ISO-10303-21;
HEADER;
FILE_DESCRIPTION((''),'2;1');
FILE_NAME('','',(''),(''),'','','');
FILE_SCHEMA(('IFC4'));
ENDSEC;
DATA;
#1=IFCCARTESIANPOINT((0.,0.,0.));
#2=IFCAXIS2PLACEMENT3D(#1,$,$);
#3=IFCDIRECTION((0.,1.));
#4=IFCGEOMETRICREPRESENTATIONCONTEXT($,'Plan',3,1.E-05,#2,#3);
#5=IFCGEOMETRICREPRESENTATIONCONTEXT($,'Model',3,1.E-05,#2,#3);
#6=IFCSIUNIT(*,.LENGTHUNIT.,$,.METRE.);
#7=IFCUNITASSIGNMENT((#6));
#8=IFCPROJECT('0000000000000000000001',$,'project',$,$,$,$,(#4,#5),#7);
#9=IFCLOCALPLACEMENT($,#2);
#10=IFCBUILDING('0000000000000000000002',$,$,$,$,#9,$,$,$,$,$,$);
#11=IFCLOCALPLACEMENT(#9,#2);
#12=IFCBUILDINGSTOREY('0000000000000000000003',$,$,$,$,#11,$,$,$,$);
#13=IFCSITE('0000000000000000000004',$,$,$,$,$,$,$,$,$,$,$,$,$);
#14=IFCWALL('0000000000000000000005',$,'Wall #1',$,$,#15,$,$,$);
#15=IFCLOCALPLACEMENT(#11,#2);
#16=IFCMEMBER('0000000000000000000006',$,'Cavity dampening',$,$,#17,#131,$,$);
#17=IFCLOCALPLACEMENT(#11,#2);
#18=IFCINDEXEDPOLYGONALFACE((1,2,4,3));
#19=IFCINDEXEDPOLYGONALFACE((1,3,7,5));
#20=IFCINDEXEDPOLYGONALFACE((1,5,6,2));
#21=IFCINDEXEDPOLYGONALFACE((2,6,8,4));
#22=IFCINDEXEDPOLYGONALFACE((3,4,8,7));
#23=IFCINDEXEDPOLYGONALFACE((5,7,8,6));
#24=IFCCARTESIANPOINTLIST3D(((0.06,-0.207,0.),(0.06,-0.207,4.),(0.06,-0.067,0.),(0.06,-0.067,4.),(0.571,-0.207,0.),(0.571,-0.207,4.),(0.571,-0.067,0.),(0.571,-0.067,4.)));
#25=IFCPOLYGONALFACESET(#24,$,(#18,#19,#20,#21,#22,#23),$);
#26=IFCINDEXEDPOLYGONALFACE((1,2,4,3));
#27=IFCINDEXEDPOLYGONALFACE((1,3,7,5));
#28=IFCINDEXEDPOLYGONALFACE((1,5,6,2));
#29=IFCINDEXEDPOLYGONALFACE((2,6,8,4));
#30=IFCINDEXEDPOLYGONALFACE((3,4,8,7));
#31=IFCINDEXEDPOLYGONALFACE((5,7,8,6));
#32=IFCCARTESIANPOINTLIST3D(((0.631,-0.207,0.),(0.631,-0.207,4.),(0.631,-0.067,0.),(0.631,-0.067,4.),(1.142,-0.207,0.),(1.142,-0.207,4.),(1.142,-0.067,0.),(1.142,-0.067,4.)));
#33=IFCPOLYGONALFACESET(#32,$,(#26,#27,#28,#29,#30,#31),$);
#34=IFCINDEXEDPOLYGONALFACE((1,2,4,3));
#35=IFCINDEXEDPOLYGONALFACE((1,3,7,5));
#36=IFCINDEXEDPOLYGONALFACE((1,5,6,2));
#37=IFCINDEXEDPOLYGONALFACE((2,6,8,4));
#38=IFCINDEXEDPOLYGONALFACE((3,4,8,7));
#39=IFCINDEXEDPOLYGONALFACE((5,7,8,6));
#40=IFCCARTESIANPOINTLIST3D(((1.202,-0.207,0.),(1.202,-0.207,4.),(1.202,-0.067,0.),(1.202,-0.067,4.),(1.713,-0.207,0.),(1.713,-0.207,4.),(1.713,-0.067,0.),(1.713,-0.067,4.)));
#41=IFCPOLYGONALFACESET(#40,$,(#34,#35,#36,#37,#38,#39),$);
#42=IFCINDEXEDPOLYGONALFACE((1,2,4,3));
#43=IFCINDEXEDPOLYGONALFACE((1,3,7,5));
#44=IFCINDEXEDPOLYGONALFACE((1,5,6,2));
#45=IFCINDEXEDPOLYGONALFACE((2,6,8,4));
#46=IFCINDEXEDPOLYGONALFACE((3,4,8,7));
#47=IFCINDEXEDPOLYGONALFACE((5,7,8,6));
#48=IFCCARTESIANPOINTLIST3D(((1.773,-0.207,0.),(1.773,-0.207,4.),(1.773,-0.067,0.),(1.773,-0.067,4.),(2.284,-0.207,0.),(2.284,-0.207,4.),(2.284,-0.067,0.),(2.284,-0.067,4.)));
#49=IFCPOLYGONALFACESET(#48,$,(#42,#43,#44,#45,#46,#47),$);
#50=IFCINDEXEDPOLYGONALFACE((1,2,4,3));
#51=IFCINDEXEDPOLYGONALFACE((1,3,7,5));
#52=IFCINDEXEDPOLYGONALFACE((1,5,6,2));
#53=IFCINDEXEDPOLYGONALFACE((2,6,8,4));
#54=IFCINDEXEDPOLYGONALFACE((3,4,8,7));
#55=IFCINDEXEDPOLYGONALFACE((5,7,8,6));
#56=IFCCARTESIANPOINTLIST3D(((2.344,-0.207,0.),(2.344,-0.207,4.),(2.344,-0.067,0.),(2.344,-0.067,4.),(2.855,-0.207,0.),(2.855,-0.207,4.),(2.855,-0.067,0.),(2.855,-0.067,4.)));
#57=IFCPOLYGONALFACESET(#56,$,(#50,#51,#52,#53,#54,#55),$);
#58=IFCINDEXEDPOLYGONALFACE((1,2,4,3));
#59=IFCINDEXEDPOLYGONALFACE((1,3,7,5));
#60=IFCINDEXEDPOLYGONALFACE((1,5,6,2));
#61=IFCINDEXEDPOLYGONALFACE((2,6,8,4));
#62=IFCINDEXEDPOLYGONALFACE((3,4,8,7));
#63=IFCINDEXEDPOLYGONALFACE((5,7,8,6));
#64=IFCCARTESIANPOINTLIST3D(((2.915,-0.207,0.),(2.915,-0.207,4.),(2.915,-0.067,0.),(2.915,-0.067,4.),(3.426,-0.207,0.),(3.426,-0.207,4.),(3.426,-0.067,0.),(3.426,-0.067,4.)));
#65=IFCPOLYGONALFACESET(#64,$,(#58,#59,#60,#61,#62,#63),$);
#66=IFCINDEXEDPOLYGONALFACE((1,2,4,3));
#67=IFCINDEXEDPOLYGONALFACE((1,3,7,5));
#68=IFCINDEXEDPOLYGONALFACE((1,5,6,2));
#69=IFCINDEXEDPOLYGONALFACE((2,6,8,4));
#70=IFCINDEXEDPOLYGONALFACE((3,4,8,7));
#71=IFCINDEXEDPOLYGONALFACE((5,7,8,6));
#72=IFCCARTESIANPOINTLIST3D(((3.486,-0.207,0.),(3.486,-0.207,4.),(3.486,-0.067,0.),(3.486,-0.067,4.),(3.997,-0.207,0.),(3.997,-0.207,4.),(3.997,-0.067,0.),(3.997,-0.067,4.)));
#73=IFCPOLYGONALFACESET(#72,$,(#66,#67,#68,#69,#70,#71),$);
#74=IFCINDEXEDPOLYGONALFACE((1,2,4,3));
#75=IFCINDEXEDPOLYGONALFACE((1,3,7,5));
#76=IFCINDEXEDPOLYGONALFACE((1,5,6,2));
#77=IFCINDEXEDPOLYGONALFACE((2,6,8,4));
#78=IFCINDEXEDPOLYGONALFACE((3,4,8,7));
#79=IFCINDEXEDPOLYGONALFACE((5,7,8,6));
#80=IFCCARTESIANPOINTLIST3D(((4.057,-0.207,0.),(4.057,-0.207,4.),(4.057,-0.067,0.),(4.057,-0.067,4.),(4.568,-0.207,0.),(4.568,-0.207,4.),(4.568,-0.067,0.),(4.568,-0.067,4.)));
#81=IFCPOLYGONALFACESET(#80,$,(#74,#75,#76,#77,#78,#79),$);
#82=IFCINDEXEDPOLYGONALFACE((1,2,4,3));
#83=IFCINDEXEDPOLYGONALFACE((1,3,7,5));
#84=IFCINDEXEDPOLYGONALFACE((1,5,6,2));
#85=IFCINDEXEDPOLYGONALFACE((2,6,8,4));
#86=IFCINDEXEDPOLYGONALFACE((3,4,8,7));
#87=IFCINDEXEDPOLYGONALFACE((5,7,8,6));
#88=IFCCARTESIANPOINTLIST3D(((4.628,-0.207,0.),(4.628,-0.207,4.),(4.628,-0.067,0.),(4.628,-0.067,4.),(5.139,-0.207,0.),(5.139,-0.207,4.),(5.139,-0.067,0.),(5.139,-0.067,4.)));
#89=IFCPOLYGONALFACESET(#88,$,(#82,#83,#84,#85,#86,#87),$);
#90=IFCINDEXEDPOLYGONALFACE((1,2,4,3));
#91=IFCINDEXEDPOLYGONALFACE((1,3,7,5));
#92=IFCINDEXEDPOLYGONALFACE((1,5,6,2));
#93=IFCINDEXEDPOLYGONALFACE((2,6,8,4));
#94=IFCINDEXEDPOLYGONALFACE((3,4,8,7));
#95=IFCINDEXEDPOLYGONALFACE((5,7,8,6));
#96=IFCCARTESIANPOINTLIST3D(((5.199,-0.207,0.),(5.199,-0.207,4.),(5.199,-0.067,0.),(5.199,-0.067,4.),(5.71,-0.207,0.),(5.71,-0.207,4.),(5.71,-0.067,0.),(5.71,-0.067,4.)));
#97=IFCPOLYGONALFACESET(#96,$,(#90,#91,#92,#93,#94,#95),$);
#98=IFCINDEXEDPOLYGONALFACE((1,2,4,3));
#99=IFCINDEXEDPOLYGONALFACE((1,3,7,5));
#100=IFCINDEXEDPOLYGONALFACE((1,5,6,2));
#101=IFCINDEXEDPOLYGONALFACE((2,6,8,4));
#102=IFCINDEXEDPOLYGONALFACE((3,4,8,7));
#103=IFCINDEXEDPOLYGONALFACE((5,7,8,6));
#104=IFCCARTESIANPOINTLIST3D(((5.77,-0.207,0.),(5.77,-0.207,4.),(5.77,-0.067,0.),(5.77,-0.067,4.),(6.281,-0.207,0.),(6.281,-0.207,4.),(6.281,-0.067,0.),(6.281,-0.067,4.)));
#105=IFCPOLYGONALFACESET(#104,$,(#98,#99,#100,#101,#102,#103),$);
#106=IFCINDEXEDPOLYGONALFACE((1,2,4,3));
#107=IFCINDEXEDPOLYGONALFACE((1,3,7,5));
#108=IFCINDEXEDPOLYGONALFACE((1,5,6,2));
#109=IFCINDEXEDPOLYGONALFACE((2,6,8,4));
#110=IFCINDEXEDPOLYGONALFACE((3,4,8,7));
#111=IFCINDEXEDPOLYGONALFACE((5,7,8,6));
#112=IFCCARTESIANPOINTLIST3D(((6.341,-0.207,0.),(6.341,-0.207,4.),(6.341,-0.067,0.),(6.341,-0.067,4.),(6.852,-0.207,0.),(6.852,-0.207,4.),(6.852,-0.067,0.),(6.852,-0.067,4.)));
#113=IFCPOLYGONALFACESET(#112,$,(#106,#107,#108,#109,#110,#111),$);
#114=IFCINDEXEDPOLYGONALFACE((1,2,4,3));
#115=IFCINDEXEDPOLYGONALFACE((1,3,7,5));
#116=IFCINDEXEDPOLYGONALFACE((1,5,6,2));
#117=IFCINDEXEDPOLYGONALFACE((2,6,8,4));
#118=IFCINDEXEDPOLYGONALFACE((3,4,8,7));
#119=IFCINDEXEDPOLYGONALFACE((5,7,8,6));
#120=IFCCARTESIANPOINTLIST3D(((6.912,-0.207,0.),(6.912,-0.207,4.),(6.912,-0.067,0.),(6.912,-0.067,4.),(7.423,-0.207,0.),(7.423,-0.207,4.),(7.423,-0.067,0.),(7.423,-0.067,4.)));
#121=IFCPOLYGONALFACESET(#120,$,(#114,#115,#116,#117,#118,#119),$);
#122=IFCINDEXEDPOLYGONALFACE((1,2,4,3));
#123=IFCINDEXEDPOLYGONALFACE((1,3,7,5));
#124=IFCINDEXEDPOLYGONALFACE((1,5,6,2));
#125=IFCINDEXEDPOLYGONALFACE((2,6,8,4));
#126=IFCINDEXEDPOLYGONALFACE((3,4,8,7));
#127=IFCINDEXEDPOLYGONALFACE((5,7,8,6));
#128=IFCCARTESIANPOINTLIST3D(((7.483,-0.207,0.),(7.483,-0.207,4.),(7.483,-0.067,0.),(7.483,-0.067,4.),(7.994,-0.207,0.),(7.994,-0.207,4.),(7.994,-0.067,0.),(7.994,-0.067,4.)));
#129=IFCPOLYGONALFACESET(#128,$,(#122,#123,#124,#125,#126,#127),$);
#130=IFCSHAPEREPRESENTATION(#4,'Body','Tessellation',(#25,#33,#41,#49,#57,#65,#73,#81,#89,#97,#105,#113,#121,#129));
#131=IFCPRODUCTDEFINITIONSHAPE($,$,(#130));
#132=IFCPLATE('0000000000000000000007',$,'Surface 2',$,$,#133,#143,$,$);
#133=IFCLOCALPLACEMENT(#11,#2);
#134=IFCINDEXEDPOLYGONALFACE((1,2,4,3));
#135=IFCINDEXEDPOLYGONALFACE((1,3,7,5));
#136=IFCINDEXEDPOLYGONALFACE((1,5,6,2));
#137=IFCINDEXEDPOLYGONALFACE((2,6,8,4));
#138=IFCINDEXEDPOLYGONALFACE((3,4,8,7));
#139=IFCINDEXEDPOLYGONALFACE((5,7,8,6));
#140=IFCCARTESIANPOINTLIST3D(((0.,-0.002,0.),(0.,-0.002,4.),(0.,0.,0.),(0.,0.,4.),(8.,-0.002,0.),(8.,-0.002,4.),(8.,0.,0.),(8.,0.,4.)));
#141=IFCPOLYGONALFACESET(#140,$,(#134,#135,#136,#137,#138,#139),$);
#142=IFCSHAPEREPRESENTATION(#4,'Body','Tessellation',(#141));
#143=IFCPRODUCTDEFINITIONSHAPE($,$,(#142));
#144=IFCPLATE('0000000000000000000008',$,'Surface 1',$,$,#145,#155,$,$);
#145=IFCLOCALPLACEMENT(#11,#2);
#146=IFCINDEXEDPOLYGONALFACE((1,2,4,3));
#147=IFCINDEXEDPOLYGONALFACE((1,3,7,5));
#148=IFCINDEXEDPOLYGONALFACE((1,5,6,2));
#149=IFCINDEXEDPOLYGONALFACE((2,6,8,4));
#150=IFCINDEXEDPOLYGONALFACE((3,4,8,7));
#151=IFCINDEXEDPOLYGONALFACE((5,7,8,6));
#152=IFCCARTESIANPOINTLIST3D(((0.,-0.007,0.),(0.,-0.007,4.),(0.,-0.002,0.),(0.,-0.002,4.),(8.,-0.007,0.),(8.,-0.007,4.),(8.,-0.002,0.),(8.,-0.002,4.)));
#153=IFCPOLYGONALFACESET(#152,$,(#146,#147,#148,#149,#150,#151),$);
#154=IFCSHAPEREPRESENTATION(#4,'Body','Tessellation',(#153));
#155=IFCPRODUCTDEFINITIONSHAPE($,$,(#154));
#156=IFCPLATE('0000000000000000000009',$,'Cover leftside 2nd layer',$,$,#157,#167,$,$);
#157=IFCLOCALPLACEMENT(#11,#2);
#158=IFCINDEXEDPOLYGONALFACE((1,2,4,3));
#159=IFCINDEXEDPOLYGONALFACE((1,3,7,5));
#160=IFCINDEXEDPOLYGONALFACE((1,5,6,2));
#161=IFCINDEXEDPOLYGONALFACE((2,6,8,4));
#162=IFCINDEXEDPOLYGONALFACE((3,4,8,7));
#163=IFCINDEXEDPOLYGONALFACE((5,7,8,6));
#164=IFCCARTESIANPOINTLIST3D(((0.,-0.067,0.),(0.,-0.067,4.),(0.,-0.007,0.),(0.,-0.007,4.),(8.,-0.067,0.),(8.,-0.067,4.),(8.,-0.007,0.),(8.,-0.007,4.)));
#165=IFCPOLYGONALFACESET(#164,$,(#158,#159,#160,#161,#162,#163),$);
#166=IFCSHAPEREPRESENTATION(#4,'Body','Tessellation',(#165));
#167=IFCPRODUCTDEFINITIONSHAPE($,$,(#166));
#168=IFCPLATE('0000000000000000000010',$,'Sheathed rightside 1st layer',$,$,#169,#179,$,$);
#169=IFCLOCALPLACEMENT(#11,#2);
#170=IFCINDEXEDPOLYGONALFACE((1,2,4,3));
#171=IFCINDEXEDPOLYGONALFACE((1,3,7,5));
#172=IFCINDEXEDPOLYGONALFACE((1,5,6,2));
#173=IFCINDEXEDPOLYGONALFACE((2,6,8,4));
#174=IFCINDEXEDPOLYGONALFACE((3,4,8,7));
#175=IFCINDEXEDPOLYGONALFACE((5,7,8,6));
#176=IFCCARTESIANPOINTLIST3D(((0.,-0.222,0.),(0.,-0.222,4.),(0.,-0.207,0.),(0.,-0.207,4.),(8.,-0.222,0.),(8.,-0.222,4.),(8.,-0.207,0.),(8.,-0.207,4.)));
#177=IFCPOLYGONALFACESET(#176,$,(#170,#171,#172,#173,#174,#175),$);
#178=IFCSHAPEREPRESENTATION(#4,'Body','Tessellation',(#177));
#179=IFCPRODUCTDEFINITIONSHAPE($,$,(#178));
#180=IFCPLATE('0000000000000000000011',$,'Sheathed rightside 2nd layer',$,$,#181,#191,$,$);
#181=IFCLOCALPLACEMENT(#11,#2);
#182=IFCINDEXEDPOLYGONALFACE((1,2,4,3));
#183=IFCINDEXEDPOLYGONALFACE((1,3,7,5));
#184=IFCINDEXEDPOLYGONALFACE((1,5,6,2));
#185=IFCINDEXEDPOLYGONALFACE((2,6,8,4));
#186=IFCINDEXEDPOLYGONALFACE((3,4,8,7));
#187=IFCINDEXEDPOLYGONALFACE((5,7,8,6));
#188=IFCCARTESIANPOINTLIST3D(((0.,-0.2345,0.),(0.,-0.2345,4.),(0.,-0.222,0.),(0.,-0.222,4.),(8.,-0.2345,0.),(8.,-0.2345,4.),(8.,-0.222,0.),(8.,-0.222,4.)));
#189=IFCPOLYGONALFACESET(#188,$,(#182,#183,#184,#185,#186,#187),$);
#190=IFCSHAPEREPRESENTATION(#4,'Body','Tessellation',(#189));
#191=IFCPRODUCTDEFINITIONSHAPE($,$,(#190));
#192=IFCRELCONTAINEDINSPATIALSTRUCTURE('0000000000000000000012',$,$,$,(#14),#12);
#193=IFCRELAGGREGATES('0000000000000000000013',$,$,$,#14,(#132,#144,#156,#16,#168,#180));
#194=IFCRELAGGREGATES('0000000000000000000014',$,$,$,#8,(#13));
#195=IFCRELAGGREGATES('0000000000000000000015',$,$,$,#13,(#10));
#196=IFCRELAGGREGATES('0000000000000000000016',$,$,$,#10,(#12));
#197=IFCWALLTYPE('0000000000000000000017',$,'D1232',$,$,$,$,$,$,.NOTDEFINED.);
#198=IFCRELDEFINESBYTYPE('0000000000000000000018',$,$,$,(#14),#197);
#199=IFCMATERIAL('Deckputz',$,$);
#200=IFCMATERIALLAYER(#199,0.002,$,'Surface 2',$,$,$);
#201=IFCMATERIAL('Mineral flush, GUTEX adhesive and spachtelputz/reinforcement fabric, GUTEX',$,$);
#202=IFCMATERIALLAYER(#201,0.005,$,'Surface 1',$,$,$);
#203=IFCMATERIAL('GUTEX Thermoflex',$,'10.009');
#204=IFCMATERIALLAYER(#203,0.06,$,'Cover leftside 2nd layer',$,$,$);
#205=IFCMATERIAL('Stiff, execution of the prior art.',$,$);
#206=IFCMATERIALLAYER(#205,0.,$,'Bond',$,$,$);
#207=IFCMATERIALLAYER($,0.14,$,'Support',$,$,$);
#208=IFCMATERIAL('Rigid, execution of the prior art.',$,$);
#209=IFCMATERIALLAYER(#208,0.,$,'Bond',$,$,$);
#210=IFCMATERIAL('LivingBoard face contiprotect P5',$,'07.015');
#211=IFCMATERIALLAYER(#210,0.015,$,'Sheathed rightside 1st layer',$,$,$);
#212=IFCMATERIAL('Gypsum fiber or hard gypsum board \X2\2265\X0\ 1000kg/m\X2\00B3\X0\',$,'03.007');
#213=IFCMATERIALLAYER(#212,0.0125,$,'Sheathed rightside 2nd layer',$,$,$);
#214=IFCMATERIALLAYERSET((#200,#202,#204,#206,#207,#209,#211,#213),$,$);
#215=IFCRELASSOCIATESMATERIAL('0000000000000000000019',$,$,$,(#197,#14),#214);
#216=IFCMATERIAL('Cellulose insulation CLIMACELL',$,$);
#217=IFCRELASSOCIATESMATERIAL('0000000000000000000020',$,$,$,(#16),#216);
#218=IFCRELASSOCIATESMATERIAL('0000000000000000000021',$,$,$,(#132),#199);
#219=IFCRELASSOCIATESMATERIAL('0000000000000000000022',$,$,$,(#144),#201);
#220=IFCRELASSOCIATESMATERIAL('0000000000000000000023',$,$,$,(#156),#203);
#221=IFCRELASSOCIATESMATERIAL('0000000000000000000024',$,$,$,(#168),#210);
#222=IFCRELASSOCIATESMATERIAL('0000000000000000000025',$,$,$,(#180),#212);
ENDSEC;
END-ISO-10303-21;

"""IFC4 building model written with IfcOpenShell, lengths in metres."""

from ifc_helpers import new_model, si_unit, direction, frame, frame_2d, origin, origin_with_axes, place, context, project, spatial, rectangle, extrude, material, layer, layer_set, type_object, element, aggregate, save


model = new_model("IFC4")

# Units and contexts
plan_context = context("Plan", 3, precision=1e-05, world=origin(), true_north=direction((0.0, 1.0)))
model_context = context("Model", 3, precision=1e-05, world=origin(), true_north=direction((0.0, 1.0)))
ifc_project = project(units=[si_unit("LENGTHUNIT", "METRE")], contexts=[plan_context, model_context])

# Site, building, storey
site = spatial("IfcSite", under=ifc_project)
building_placement = place(None, origin())
building = spatial("IfcBuilding", under=site, at=building_placement)
storey_placement = place(building_placement, origin())
storey = spatial("IfcBuildingStorey", under=building, at=storey_placement)

# Wall, member, plates
ifc_material_1 = material(Name="Deckputz")
ifc_layer_1 = layer(ifc_material_1, 0.002, Name="Surface 2")
ifc_material_2 = material(Name="Mineral flush, GUTEX adhesive and spachtelputz/reinforcement fabric, GUTEX")
ifc_layer_2 = layer(ifc_material_2, 0.005, Name="Surface 1")
ifc_material_3 = material(Name="GUTEX Thermoflex", Category="10.009")
ifc_layer_3 = layer(ifc_material_3, 0.06, Name="Cover leftside 2nd layer")
ifc_material_4 = material(Name="Stiff, execution of the prior art.")
ifc_layer_4 = layer(ifc_material_4, 0.0, Name="Bond")
ifc_layer_5 = layer(None, 0.14, Name="Support")
ifc_material_5 = material(Name="Rigid, execution of the prior art.")
ifc_layer_6 = layer(ifc_material_5, 0.0, Name="Bond")
ifc_material_6 = material(Name="LivingBoard face contiprotect P5", Category="07.015")
ifc_layer_7 = layer(ifc_material_6, 0.015, Name="Sheathed rightside 1st layer")
ifc_material_7 = material(Name="Gypsum fiber or hard gypsum board ≥ 1000kg/m³", Category="03.007")
ifc_layer_8 = layer(ifc_material_7, 0.0125, Name="Sheathed rightside 2nd layer")
ifc_layer_set = layer_set([ifc_layer_1, ifc_layer_2, ifc_layer_3, ifc_layer_4, ifc_layer_5, ifc_layer_6, ifc_layer_7, ifc_layer_8])
wall_type = type_object("IfcWallType", Name="D1232", PredefinedType="NOTDEFINED", material=ifc_layer_set)
wall_placement = place(None, frame((0.0, 0.0, 0.0), z_axis=(0.0, -1.0, 0.0), x_axis=(1.0, 0.0, 0.0)))
wall = element("IfcWall", 1, at=wall_placement, inside=storey, type_object=wall_type, material=ifc_layer_set, Name="Wall #1")
ifc_material_8 = material(Name="Cellulose insulation CLIMACELL")
member_1_placement = place(wall_placement, origin())
member_1 = element("IfcMember", 2, at=member_1_placement, material=ifc_material_8, Name="Cavity dampening", context=plan_context, shape_type="SweptSolid", body=[
    extrude(rectangle(XDim=0.511, YDim=0.14, at=frame_2d((0.2555, 0.07), x_axis=(1.0, 0.0))), frame((0.06, 4.0, 0.067), z_axis=(0.0, -1.0, 0.0), x_axis=(1.0, 0.0, 0.0)), (0.0, 0.0, 1.0), 4.0),
    extrude(rectangle(XDim=0.511, YDim=0.14, at=frame_2d((0.2555, 0.07), x_axis=(1.0, 0.0))), frame((0.631, 4.0, 0.067), z_axis=(0.0, -1.0, 0.0), x_axis=(1.0, 0.0, 0.0)), (0.0, 0.0, 1.0), 4.0),
    extrude(rectangle(XDim=0.511, YDim=0.14, at=frame_2d((0.2555, 0.07), x_axis=(1.0, 0.0))), frame((1.202, 4.0, 0.067), z_axis=(0.0, -1.0, 0.0), x_axis=(1.0, 0.0, 0.0)), (0.0, 0.0, 1.0), 4.0),
    extrude(rectangle(XDim=0.511, YDim=0.14, at=frame_2d((0.2555, 0.07), x_axis=(1.0, 0.0))), frame((1.773, 4.0, 0.067), z_axis=(0.0, -1.0, 0.0), x_axis=(1.0, 0.0, 0.0)), (0.0, 0.0, 1.0), 4.0),
    extrude(rectangle(XDim=0.511, YDim=0.14, at=frame_2d((0.2555, 0.07), x_axis=(1.0, 0.0))), frame((2.344, 4.0, 0.067), z_axis=(0.0, -1.0, 0.0), x_axis=(1.0, 0.0, 0.0)), (0.0, 0.0, 1.0), 4.0),
    extrude(rectangle(XDim=0.511, YDim=0.14, at=frame_2d((0.2555, 0.07), x_axis=(1.0, 0.0))), frame((2.915, 4.0, 0.067), z_axis=(0.0, -1.0, 0.0), x_axis=(1.0, 0.0, 0.0)), (0.0, 0.0, 1.0), 4.0),
    extrude(rectangle(XDim=0.511, YDim=0.14, at=frame_2d((0.2555, 0.07), x_axis=(1.0, 0.0))), frame((3.486, 4.0, 0.067), z_axis=(0.0, -1.0, 0.0), x_axis=(1.0, 0.0, 0.0)), (0.0, 0.0, 1.0), 4.0),
    extrude(rectangle(XDim=0.511, YDim=0.14, at=frame_2d((0.2555, 0.07), x_axis=(1.0, 0.0))), frame((4.057, 4.0, 0.067), z_axis=(0.0, -1.0, 0.0), x_axis=(1.0, 0.0, 0.0)), (0.0, 0.0, 1.0), 4.0),
    extrude(rectangle(XDim=0.511, YDim=0.14, at=frame_2d((0.2555, 0.07), x_axis=(1.0, 0.0))), frame((4.628, 4.0, 0.067), z_axis=(0.0, -1.0, 0.0), x_axis=(1.0, 0.0, 0.0)), (0.0, 0.0, 1.0), 4.0),
    extrude(rectangle(XDim=0.511, YDim=0.14, at=frame_2d((0.2555, 0.07), x_axis=(1.0, 0.0))), frame((5.199, 4.0, 0.067), z_axis=(0.0, -1.0, 0.0), x_axis=(1.0, 0.0, 0.0)), (0.0, 0.0, 1.0), 4.0),
    extrude(rectangle(XDim=0.511, YDim=0.14, at=frame_2d((0.2555, 0.07), x_axis=(1.0, 0.0))), frame((5.77, 4.0, 0.067), z_axis=(0.0, -1.0, 0.0), x_axis=(1.0, 0.0, 0.0)), (0.0, 0.0, 1.0), 4.0),
    extrude(rectangle(XDim=0.511, YDim=0.14, at=frame_2d((0.2555, 0.07), x_axis=(1.0, 0.0))), frame((6.341, 4.0, 0.067), z_axis=(0.0, -1.0, 0.0), x_axis=(1.0, 0.0, 0.0)), (0.0, 0.0, 1.0), 4.0),
    extrude(rectangle(XDim=0.511, YDim=0.14, at=frame_2d((0.2555, 0.07), x_axis=(1.0, 0.0))), frame((6.912, 4.0, 0.067), z_axis=(0.0, -1.0, 0.0), x_axis=(1.0, 0.0, 0.0)), (0.0, 0.0, 1.0), 4.0),
    extrude(rectangle(XDim=0.511, YDim=0.14, at=frame_2d((0.2555, 0.07), x_axis=(1.0, 0.0))), frame((7.483, 4.0, 0.067), z_axis=(0.0, -1.0, 0.0), x_axis=(1.0, 0.0, 0.0)), (0.0, 0.0, 1.0), 4.0),
])
plate_1_placement = place(wall_placement, origin())
plate_1 = element("IfcPlate", 3, at=plate_1_placement, material=ifc_material_1, Name="Surface 2", context=plan_context, shape_type="SweptSolid", body=[
    extrude(rectangle(XDim=8.0, YDim=4.0, at=frame_2d((4.0, 2.0), x_axis=(1.0, 0.0))), origin_with_axes(), (0.0, 0.0, 1.0), 0.002),
])
plate_2_placement = place(wall_placement, origin())
plate_2 = element("IfcPlate", 4, at=plate_2_placement, material=ifc_material_2, Name="Surface 1", context=plan_context, shape_type="SweptSolid", body=[
    extrude(rectangle(XDim=8.0, YDim=4.0, at=frame_2d((4.0, 2.0), x_axis=(1.0, 0.0))), frame((0.0, 0.0, 0.002), z_axis=(0.0, 0.0, 1.0), x_axis=(1.0, 0.0, 0.0)), (0.0, 0.0, 1.0), 0.005),
])
plate_3_placement = place(wall_placement, origin())
plate_3 = element("IfcPlate", 5, at=plate_3_placement, material=ifc_material_3, Name="Cover leftside 2nd layer", context=plan_context, shape_type="SweptSolid", body=[
    extrude(rectangle(XDim=8.0, YDim=4.0, at=frame_2d((4.0, 2.0), x_axis=(1.0, 0.0))), frame((0.0, 0.0, 0.007), z_axis=(0.0, 0.0, 1.0), x_axis=(1.0, 0.0, 0.0)), (0.0, 0.0, 1.0), 0.06),
])
plate_4_placement = place(wall_placement, origin())
plate_4 = element("IfcPlate", 6, at=plate_4_placement, material=ifc_material_6, Name="Sheathed rightside 1st layer", context=plan_context, shape_type="SweptSolid", body=[
    extrude(rectangle(XDim=8.0, YDim=4.0, at=frame_2d((4.0, 2.0), x_axis=(1.0, 0.0))), frame((0.0, 0.0, 0.207), z_axis=(0.0, 0.0, 1.0), x_axis=(1.0, 0.0, 0.0)), (0.0, 0.0, 1.0), 0.015),
])
plate_5_placement = place(wall_placement, origin())
plate_5 = element("IfcPlate", 7, at=plate_5_placement, material=ifc_material_7, Name="Sheathed rightside 2nd layer", context=plan_context, shape_type="SweptSolid", body=[
    extrude(rectangle(XDim=8.0, YDim=4.0, at=frame_2d((4.0, 2.0), x_axis=(1.0, 0.0))), frame((0.0, 0.0, 0.222), z_axis=(0.0, 0.0, 1.0), x_axis=(1.0, 0.0, 0.0)), (0.0, 0.0, 1.0), 0.0125),
])
aggregate(wall, [plate_1, plate_2, plate_3, member_1, plate_4, plate_5])

save(model, "model.ifc")
